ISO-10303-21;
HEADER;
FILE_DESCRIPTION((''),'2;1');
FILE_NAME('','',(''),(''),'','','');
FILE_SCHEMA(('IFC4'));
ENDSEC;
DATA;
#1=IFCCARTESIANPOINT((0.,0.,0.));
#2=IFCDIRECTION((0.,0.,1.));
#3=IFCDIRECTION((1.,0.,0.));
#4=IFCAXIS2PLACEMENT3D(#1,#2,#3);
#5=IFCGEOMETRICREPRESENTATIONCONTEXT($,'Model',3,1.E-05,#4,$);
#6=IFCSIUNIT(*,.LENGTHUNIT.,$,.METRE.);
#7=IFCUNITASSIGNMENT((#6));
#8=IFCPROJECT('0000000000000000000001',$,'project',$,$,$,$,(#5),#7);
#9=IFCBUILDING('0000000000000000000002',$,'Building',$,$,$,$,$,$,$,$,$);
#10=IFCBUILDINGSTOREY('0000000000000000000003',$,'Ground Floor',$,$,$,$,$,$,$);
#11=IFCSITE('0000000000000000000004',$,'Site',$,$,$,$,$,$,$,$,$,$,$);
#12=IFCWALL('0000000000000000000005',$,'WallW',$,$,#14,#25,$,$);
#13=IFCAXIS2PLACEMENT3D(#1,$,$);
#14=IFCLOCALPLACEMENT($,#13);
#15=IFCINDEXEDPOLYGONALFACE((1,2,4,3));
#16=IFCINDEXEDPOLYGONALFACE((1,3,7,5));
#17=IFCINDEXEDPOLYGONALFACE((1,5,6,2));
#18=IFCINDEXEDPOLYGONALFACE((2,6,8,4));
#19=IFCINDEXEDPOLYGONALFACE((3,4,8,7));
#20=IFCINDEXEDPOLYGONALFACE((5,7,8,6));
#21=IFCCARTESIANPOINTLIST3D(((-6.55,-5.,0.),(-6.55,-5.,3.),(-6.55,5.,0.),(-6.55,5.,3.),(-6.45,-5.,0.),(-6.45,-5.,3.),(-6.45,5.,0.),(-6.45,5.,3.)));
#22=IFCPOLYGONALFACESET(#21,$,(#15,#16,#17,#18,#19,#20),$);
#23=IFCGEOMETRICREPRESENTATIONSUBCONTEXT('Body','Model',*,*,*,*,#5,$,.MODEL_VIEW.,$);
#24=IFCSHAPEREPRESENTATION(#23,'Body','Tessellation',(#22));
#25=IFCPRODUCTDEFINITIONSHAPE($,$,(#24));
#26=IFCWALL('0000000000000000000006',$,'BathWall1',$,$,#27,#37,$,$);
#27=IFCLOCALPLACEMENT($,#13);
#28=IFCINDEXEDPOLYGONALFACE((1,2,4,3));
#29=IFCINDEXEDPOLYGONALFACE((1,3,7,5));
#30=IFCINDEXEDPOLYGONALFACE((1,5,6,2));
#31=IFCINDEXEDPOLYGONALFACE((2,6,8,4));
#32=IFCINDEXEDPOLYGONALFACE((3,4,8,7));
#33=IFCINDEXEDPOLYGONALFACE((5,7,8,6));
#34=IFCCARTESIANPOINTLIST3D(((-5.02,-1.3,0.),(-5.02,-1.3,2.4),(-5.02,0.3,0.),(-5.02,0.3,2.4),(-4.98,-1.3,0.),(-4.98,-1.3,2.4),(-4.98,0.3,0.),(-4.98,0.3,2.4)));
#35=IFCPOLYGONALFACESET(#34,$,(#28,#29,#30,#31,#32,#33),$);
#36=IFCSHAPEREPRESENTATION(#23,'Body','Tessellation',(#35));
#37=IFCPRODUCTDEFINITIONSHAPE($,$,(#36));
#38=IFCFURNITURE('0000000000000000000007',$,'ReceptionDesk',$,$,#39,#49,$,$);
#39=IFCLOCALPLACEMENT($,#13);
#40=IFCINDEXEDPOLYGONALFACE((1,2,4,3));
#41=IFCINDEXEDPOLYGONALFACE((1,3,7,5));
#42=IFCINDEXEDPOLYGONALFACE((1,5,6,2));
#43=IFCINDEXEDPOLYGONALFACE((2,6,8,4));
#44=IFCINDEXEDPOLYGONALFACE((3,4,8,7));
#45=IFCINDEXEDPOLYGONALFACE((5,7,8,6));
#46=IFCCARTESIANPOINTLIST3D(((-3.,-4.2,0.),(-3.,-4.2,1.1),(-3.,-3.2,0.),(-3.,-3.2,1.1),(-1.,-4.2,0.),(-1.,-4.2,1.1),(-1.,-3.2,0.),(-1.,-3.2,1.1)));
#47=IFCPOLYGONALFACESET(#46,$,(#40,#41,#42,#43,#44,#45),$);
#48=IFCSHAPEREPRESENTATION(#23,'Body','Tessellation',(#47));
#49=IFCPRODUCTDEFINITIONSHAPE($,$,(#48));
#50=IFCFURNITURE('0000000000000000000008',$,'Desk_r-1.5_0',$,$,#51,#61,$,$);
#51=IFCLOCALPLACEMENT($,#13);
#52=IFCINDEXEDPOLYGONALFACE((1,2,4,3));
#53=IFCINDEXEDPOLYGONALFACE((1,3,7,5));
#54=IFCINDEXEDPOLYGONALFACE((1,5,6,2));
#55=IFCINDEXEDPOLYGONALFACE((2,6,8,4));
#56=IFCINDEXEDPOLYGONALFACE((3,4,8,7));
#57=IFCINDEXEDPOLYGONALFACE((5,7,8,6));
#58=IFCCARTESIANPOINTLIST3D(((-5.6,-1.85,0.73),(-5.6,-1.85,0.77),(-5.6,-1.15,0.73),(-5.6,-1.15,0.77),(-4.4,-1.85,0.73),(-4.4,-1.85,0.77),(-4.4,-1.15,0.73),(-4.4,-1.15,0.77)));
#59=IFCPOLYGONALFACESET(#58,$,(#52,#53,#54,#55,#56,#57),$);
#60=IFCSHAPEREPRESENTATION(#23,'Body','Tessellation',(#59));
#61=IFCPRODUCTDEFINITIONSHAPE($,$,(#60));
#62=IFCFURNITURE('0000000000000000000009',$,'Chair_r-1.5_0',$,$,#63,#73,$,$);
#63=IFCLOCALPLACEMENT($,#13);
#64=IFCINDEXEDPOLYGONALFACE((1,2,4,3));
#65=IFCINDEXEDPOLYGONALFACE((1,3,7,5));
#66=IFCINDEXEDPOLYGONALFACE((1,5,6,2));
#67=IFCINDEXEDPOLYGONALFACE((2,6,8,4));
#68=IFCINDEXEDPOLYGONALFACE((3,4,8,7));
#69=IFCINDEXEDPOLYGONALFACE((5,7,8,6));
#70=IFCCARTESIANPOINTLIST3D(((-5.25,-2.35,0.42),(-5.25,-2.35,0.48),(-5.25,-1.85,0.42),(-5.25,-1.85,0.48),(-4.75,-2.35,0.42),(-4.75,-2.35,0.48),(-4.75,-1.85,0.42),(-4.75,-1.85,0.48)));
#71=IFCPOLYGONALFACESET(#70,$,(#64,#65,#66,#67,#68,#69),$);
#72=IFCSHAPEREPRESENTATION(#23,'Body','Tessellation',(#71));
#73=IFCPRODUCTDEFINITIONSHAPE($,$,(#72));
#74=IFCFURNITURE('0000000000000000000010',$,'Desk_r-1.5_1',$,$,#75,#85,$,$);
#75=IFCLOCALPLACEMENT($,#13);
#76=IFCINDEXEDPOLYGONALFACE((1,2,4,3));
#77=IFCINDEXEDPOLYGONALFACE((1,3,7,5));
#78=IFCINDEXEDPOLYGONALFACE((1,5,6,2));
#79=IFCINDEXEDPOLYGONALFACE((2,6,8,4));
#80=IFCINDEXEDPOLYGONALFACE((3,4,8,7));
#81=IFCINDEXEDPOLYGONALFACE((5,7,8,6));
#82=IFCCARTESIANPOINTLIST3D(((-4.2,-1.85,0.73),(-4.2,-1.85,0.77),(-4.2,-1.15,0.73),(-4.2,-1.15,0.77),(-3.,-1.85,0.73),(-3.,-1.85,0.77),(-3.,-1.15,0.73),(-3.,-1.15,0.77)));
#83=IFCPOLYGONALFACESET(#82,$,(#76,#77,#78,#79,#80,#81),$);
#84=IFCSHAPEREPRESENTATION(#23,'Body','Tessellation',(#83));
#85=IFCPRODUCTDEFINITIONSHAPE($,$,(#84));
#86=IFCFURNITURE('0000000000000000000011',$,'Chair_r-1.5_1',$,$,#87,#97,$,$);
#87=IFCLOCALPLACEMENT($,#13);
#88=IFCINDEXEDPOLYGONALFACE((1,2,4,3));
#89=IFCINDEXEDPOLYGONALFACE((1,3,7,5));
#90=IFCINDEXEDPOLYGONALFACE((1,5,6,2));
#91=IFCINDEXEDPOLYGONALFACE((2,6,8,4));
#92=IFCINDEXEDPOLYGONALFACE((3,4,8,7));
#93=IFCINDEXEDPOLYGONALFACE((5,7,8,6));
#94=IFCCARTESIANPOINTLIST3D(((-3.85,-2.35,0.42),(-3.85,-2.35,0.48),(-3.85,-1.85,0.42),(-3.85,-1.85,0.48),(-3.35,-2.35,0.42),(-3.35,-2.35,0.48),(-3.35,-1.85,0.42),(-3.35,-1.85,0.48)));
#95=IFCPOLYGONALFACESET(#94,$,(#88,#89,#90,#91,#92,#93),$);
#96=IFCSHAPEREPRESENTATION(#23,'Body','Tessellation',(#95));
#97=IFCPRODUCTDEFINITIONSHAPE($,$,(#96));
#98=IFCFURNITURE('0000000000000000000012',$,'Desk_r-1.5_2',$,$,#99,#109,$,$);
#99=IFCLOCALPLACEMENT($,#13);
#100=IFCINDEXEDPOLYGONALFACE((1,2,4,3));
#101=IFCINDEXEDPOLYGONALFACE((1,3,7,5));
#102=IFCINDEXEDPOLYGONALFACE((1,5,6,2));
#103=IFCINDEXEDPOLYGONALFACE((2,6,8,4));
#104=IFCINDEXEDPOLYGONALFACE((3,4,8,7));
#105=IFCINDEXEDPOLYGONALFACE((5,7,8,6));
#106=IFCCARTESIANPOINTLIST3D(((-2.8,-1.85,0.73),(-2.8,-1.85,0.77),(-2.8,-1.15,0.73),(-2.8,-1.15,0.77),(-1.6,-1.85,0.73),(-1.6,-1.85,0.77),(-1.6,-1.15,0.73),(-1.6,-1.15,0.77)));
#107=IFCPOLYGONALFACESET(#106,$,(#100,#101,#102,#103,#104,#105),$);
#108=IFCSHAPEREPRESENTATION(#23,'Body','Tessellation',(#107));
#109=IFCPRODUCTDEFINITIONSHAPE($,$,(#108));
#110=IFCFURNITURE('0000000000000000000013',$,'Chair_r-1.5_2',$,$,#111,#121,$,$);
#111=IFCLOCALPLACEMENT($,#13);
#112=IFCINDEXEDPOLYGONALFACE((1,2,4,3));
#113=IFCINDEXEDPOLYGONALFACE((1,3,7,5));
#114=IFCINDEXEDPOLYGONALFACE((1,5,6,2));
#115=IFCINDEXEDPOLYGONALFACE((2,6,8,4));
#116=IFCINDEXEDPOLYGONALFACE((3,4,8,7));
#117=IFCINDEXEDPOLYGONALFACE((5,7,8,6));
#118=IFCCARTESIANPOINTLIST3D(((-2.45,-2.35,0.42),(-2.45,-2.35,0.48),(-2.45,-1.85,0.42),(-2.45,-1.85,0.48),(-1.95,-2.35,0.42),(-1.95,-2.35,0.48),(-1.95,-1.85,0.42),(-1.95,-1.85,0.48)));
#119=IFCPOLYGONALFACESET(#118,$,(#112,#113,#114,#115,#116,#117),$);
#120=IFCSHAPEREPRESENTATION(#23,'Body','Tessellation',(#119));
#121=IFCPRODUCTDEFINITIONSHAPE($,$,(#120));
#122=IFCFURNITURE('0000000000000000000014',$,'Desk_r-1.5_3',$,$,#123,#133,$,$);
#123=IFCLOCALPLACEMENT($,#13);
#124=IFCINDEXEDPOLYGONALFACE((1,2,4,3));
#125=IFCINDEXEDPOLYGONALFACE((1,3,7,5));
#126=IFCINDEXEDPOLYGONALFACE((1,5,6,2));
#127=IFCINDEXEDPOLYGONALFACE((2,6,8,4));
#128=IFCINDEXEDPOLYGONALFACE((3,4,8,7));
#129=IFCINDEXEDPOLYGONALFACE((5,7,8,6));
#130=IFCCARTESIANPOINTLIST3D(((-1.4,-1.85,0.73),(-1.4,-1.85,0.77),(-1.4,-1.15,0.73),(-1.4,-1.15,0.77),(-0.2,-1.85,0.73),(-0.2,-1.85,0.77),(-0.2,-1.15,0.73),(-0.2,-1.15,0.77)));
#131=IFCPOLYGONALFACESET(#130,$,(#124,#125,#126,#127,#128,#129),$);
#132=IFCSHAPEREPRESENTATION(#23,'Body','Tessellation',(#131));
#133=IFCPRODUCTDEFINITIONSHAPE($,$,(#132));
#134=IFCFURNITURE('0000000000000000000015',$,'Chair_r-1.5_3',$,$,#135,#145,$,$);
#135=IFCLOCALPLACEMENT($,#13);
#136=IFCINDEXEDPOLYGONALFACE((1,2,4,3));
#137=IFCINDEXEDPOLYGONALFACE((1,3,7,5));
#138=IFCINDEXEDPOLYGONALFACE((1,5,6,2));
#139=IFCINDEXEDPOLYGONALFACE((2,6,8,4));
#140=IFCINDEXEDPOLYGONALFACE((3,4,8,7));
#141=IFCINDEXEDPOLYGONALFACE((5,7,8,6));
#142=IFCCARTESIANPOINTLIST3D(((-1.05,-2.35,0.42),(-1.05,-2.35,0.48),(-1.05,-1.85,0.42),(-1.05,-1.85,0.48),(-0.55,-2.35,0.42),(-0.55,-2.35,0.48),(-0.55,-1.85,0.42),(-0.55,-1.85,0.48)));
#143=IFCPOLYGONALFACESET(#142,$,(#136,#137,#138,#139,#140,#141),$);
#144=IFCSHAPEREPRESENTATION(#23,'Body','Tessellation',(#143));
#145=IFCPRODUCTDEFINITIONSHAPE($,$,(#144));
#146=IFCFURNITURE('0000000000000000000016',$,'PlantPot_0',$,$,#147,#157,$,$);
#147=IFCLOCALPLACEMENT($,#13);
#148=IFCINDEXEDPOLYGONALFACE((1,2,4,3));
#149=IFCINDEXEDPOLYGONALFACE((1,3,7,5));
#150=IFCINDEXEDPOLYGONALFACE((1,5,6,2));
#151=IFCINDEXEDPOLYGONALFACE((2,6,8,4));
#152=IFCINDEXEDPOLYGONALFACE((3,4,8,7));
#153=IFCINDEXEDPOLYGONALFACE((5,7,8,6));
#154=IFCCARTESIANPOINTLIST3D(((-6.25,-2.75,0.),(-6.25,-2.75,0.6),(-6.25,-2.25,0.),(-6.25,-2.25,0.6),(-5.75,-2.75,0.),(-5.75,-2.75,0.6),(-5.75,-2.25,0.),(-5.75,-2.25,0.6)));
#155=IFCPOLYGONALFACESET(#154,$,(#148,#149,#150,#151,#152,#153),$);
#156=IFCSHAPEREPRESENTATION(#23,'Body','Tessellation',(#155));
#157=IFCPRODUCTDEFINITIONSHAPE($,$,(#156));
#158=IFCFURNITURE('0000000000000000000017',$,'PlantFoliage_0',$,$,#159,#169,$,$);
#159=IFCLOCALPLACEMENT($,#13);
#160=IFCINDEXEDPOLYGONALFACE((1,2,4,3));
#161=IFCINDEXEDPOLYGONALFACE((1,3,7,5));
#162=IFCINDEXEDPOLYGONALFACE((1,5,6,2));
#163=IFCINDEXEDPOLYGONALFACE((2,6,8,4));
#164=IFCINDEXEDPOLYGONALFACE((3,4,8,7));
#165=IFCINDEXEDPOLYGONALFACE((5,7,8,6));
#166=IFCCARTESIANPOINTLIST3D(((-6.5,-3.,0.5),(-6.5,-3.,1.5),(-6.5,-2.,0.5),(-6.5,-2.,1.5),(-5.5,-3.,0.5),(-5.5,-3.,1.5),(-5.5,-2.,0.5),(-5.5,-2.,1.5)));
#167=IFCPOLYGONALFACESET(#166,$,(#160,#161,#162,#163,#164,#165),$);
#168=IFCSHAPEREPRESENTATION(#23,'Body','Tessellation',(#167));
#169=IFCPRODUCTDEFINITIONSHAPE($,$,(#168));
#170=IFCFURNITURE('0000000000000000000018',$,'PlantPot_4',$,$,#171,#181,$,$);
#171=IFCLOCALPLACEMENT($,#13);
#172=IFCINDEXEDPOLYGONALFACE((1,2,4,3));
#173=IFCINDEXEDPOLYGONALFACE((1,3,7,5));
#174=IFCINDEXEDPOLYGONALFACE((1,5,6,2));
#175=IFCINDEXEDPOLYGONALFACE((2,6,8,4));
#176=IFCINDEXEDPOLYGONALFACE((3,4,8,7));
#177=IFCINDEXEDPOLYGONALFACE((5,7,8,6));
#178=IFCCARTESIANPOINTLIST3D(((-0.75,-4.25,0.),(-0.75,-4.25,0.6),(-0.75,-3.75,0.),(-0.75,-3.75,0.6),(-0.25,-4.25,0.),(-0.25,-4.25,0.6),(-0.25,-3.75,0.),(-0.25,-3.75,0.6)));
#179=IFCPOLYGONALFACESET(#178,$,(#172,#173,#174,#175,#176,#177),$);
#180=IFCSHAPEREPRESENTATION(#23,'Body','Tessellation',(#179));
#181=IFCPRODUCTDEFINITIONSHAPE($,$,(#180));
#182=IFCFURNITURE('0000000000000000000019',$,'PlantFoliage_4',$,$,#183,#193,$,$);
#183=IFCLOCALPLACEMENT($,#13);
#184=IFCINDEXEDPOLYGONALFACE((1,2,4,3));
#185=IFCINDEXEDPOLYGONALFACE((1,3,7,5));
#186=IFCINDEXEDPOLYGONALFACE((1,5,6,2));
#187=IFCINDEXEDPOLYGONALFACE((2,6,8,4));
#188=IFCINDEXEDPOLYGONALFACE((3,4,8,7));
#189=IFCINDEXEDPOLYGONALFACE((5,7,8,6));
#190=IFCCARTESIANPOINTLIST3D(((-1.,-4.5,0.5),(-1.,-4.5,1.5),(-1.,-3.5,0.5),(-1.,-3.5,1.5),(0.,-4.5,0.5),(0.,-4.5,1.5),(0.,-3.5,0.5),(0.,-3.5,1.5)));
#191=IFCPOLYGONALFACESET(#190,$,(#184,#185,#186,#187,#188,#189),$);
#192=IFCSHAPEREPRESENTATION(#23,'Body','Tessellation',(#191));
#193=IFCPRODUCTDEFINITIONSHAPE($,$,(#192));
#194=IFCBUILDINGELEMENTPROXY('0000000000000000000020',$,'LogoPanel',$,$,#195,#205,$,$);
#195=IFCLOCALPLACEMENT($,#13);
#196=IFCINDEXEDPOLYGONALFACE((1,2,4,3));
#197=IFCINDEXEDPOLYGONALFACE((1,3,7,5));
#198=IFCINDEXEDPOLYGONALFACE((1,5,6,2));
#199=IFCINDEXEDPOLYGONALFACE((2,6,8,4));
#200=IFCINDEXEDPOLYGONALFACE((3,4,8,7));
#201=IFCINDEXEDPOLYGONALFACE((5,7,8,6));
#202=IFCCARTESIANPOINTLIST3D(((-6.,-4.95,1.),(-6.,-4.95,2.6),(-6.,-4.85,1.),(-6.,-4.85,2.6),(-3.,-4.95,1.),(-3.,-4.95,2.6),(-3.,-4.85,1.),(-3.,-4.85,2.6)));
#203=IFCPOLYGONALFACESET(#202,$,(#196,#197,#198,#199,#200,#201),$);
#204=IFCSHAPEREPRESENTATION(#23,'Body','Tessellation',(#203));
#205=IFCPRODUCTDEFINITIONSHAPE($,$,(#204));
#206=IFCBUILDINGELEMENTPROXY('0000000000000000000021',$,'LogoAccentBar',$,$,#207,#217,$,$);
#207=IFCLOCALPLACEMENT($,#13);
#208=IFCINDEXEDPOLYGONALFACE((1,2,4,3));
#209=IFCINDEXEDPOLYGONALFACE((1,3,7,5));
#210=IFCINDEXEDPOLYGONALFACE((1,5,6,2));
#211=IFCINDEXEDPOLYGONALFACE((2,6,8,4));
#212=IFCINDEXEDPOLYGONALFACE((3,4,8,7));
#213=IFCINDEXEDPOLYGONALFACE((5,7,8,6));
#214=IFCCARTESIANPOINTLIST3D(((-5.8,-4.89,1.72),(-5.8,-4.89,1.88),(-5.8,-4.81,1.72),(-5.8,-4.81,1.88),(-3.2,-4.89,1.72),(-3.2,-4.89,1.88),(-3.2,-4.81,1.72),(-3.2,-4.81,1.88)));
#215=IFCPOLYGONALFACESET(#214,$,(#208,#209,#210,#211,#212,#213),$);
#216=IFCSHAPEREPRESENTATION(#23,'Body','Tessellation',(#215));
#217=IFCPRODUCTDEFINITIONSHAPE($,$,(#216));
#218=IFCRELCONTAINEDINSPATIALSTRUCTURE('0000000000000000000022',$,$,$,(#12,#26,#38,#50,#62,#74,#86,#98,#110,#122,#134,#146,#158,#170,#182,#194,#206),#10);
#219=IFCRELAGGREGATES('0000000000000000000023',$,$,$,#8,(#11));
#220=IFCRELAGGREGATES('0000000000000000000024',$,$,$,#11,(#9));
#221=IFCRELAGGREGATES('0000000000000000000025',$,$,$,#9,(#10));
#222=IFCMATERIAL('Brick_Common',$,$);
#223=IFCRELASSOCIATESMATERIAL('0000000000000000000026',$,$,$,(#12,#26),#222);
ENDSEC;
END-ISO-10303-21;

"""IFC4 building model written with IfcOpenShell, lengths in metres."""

from ifc_helpers import new_model, si_unit, frame, origin_with_axes, origin_2d, place, context, subcontext, project, spatial, rectangle, extrude, material, element, save


model = new_model("IFC4")

# Units and contexts
model_context = context("Model", 3, precision=1e-05, world=origin_with_axes())
body_context = subcontext(model_context, "Body", "Model", "MODEL_VIEW")
ifc_project = project(units=[si_unit("LENGTHUNIT", "METRE")], contexts=[model_context])

# Site, building, storey
site = spatial("IfcSite", under=ifc_project, Name="Site")
building = spatial("IfcBuilding", under=site, Name="Building")
storey = spatial("IfcBuildingStorey", under=building, Name="Ground Floor")

# Walls
ifc_material = material(Name="Brick_Common")
wall_1_placement = place(None, frame((-6.5, 0.0, 1.5), z_axis=(0.0, 0.0, 1.0), x_axis=(1.0, 0.0, 0.0)))
element("IfcWall", 1, at=wall_1_placement, inside=storey, material=ifc_material, Name="WallW", context=body_context, shape_type="SweptSolid", body=[
    extrude(rectangle(XDim=0.1, YDim=10.0, at=origin_2d()), frame((0.0, 0.0, -1.5)), (0.0, 0.0, 1.0), 3.0),
])
wall_2_placement = place(None, frame((-5.0, -0.5, 1.2), z_axis=(0.0, 0.0, 1.0), x_axis=(1.0, 0.0, 0.0)))
element("IfcWall", 2, at=wall_2_placement, inside=storey, material=ifc_material, Name="BathWall1", context=body_context, shape_type="SweptSolid", body=[
    extrude(rectangle(XDim=0.04, YDim=1.6, at=origin_2d()), frame((0.0, 0.0, -1.2)), (0.0, 0.0, 1.0), 2.4),
])

# Furniture
furniture_1_placement = place(None, frame((-2.0, -3.7, 0.55), z_axis=(0.0, 0.0, 1.0), x_axis=(1.0, 0.0, 0.0)))
element("IfcFurniture", 3, at=furniture_1_placement, inside=storey, Name="ReceptionDesk", context=body_context, shape_type="SweptSolid", body=[
    extrude(rectangle(XDim=2.0, YDim=1.0, at=origin_2d()), frame((0.0, 0.0, -0.55)), (0.0, 0.0, 1.0), 1.1),
])
furniture_2_placement = place(None, frame((-5.0, -1.5, 0.75), z_axis=(0.0, 0.0, 1.0), x_axis=(1.0, 0.0, 0.0)))
element("IfcFurniture", 4, at=furniture_2_placement, inside=storey, Name="Desk_r-1.5_0", context=body_context, shape_type="SweptSolid", body=[
    extrude(rectangle(XDim=1.2, YDim=0.7, at=origin_2d()), frame((0.0, 0.0, -0.02)), (0.0, 0.0, 1.0), 0.04),
])
furniture_3_placement = place(None, frame((-5.0, -2.1, 0.45), z_axis=(0.0, 0.0, 1.0), x_axis=(1.0, 0.0, 0.0)))
element("IfcFurniture", 5, at=furniture_3_placement, inside=storey, Name="Chair_r-1.5_0", context=body_context, shape_type="SweptSolid", body=[
    extrude(rectangle(XDim=0.5, YDim=0.5, at=origin_2d()), frame((0.0, 0.0, -0.03)), (0.0, 0.0, 1.0), 0.06),
])
furniture_4_placement = place(None, frame((-3.6, -1.5, 0.75), z_axis=(0.0, 0.0, 1.0), x_axis=(1.0, 0.0, 0.0)))
element("IfcFurniture", 6, at=furniture_4_placement, inside=storey, Name="Desk_r-1.5_1", context=body_context, shape_type="SweptSolid", body=[
    extrude(rectangle(XDim=1.2, YDim=0.7, at=origin_2d()), frame((0.0, 0.0, -0.02)), (0.0, 0.0, 1.0), 0.04),
])
furniture_5_placement = place(None, frame((-3.6, -2.1, 0.45), z_axis=(0.0, 0.0, 1.0), x_axis=(1.0, 0.0, 0.0)))
element("IfcFurniture", 7, at=furniture_5_placement, inside=storey, Name="Chair_r-1.5_1", context=body_context, shape_type="SweptSolid", body=[
    extrude(rectangle(XDim=0.5, YDim=0.5, at=origin_2d()), frame((0.0, 0.0, -0.03)), (0.0, 0.0, 1.0), 0.06),
])
furniture_6_placement = place(None, frame((-2.2, -1.5, 0.75), z_axis=(0.0, 0.0, 1.0), x_axis=(1.0, 0.0, 0.0)))
element("IfcFurniture", 8, at=furniture_6_placement, inside=storey, Name="Desk_r-1.5_2", context=body_context, shape_type="SweptSolid", body=[
    extrude(rectangle(XDim=1.2, YDim=0.7, at=origin_2d()), frame((0.0, 0.0, -0.02)), (0.0, 0.0, 1.0), 0.04),
])
furniture_7_placement = place(None, frame((-2.2, -2.1, 0.45), z_axis=(0.0, 0.0, 1.0), x_axis=(1.0, 0.0, 0.0)))
element("IfcFurniture", 9, at=furniture_7_placement, inside=storey, Name="Chair_r-1.5_2", context=body_context, shape_type="SweptSolid", body=[
    extrude(rectangle(XDim=0.5, YDim=0.5, at=origin_2d()), frame((0.0, 0.0, -0.03)), (0.0, 0.0, 1.0), 0.06),
])
furniture_8_placement = place(None, frame((-0.8, -1.5, 0.75), z_axis=(0.0, 0.0, 1.0), x_axis=(1.0, 0.0, 0.0)))
element("IfcFurniture", 10, at=furniture_8_placement, inside=storey, Name="Desk_r-1.5_3", context=body_context, shape_type="SweptSolid", body=[
    extrude(rectangle(XDim=1.2, YDim=0.7, at=origin_2d()), frame((0.0, 0.0, -0.02)), (0.0, 0.0, 1.0), 0.04),
])
furniture_9_placement = place(None, frame((-0.8, -2.1, 0.45), z_axis=(0.0, 0.0, 1.0), x_axis=(1.0, 0.0, 0.0)))
element("IfcFurniture", 11, at=furniture_9_placement, inside=storey, Name="Chair_r-1.5_3", context=body_context, shape_type="SweptSolid", body=[
    extrude(rectangle(XDim=0.5, YDim=0.5, at=origin_2d()), frame((0.0, 0.0, -0.03)), (0.0, 0.0, 1.0), 0.06),
])
furniture_10_placement = place(None, frame((-6.0, -2.5, 0.3), z_axis=(0.0, 0.0, 1.0), x_axis=(1.0, 0.0, 0.0)))
element("IfcFurniture", 12, at=furniture_10_placement, inside=storey, Name="PlantPot_0", context=body_context, shape_type="SweptSolid", body=[
    extrude(rectangle(XDim=0.5, YDim=0.5, at=origin_2d()), frame((0.0, 0.0, -0.3)), (0.0, 0.0, 1.0), 0.6),
])
furniture_11_placement = place(None, frame((-6.0, -2.5, 1.0), z_axis=(0.0, 0.0, 1.0), x_axis=(1.0, 0.0, 0.0)))
element("IfcFurniture", 13, at=furniture_11_placement, inside=storey, Name="PlantFoliage_0", context=body_context, shape_type="SweptSolid", body=[
    extrude(rectangle(XDim=1.0, YDim=1.0, at=origin_2d()), frame((0.0, 0.0, -0.5)), (0.0, 0.0, 1.0), 1.0),
])
furniture_12_placement = place(None, frame((-0.5, -4.0, 0.3), z_axis=(0.0, 0.0, 1.0), x_axis=(1.0, 0.0, 0.0)))
element("IfcFurniture", 14, at=furniture_12_placement, inside=storey, Name="PlantPot_4", context=body_context, shape_type="SweptSolid", body=[
    extrude(rectangle(XDim=0.5, YDim=0.5, at=origin_2d()), frame((0.0, 0.0, -0.3)), (0.0, 0.0, 1.0), 0.6),
])
furniture_13_placement = place(None, frame((-0.5, -4.0, 1.0), z_axis=(0.0, 0.0, 1.0), x_axis=(1.0, 0.0, 0.0)))
element("IfcFurniture", 15, at=furniture_13_placement, inside=storey, Name="PlantFoliage_4", context=body_context, shape_type="SweptSolid", body=[
    extrude(rectangle(XDim=1.0, YDim=1.0, at=origin_2d()), frame((0.0, 0.0, -0.5)), (0.0, 0.0, 1.0), 1.0),
])

# Building element proxies
proxy_1_placement = place(None, frame((-4.5, -4.9, 1.8), z_axis=(0.0, 0.0, 1.0), x_axis=(1.0, 0.0, 0.0)))
element("IfcBuildingElementProxy", 16, at=proxy_1_placement, inside=storey, Name="LogoPanel", context=body_context, shape_type="SweptSolid", body=[
    extrude(rectangle(XDim=3.0, YDim=0.1, at=origin_2d()), frame((0.0, 0.0, -0.8)), (0.0, 0.0, 1.0), 1.6),
])
proxy_2_placement = place(None, frame((-4.5, -4.85, 1.8), z_axis=(0.0, 0.0, 1.0), x_axis=(1.0, 0.0, 0.0)))
element("IfcBuildingElementProxy", 17, at=proxy_2_placement, inside=storey, Name="LogoAccentBar", context=body_context, shape_type="SweptSolid", body=[
    extrude(rectangle(XDim=2.6, YDim=0.08, at=origin_2d()), frame((0.0, 0.0, -0.08)), (0.0, 0.0, 1.0), 0.16),
])

save(model, "model.ifc")
